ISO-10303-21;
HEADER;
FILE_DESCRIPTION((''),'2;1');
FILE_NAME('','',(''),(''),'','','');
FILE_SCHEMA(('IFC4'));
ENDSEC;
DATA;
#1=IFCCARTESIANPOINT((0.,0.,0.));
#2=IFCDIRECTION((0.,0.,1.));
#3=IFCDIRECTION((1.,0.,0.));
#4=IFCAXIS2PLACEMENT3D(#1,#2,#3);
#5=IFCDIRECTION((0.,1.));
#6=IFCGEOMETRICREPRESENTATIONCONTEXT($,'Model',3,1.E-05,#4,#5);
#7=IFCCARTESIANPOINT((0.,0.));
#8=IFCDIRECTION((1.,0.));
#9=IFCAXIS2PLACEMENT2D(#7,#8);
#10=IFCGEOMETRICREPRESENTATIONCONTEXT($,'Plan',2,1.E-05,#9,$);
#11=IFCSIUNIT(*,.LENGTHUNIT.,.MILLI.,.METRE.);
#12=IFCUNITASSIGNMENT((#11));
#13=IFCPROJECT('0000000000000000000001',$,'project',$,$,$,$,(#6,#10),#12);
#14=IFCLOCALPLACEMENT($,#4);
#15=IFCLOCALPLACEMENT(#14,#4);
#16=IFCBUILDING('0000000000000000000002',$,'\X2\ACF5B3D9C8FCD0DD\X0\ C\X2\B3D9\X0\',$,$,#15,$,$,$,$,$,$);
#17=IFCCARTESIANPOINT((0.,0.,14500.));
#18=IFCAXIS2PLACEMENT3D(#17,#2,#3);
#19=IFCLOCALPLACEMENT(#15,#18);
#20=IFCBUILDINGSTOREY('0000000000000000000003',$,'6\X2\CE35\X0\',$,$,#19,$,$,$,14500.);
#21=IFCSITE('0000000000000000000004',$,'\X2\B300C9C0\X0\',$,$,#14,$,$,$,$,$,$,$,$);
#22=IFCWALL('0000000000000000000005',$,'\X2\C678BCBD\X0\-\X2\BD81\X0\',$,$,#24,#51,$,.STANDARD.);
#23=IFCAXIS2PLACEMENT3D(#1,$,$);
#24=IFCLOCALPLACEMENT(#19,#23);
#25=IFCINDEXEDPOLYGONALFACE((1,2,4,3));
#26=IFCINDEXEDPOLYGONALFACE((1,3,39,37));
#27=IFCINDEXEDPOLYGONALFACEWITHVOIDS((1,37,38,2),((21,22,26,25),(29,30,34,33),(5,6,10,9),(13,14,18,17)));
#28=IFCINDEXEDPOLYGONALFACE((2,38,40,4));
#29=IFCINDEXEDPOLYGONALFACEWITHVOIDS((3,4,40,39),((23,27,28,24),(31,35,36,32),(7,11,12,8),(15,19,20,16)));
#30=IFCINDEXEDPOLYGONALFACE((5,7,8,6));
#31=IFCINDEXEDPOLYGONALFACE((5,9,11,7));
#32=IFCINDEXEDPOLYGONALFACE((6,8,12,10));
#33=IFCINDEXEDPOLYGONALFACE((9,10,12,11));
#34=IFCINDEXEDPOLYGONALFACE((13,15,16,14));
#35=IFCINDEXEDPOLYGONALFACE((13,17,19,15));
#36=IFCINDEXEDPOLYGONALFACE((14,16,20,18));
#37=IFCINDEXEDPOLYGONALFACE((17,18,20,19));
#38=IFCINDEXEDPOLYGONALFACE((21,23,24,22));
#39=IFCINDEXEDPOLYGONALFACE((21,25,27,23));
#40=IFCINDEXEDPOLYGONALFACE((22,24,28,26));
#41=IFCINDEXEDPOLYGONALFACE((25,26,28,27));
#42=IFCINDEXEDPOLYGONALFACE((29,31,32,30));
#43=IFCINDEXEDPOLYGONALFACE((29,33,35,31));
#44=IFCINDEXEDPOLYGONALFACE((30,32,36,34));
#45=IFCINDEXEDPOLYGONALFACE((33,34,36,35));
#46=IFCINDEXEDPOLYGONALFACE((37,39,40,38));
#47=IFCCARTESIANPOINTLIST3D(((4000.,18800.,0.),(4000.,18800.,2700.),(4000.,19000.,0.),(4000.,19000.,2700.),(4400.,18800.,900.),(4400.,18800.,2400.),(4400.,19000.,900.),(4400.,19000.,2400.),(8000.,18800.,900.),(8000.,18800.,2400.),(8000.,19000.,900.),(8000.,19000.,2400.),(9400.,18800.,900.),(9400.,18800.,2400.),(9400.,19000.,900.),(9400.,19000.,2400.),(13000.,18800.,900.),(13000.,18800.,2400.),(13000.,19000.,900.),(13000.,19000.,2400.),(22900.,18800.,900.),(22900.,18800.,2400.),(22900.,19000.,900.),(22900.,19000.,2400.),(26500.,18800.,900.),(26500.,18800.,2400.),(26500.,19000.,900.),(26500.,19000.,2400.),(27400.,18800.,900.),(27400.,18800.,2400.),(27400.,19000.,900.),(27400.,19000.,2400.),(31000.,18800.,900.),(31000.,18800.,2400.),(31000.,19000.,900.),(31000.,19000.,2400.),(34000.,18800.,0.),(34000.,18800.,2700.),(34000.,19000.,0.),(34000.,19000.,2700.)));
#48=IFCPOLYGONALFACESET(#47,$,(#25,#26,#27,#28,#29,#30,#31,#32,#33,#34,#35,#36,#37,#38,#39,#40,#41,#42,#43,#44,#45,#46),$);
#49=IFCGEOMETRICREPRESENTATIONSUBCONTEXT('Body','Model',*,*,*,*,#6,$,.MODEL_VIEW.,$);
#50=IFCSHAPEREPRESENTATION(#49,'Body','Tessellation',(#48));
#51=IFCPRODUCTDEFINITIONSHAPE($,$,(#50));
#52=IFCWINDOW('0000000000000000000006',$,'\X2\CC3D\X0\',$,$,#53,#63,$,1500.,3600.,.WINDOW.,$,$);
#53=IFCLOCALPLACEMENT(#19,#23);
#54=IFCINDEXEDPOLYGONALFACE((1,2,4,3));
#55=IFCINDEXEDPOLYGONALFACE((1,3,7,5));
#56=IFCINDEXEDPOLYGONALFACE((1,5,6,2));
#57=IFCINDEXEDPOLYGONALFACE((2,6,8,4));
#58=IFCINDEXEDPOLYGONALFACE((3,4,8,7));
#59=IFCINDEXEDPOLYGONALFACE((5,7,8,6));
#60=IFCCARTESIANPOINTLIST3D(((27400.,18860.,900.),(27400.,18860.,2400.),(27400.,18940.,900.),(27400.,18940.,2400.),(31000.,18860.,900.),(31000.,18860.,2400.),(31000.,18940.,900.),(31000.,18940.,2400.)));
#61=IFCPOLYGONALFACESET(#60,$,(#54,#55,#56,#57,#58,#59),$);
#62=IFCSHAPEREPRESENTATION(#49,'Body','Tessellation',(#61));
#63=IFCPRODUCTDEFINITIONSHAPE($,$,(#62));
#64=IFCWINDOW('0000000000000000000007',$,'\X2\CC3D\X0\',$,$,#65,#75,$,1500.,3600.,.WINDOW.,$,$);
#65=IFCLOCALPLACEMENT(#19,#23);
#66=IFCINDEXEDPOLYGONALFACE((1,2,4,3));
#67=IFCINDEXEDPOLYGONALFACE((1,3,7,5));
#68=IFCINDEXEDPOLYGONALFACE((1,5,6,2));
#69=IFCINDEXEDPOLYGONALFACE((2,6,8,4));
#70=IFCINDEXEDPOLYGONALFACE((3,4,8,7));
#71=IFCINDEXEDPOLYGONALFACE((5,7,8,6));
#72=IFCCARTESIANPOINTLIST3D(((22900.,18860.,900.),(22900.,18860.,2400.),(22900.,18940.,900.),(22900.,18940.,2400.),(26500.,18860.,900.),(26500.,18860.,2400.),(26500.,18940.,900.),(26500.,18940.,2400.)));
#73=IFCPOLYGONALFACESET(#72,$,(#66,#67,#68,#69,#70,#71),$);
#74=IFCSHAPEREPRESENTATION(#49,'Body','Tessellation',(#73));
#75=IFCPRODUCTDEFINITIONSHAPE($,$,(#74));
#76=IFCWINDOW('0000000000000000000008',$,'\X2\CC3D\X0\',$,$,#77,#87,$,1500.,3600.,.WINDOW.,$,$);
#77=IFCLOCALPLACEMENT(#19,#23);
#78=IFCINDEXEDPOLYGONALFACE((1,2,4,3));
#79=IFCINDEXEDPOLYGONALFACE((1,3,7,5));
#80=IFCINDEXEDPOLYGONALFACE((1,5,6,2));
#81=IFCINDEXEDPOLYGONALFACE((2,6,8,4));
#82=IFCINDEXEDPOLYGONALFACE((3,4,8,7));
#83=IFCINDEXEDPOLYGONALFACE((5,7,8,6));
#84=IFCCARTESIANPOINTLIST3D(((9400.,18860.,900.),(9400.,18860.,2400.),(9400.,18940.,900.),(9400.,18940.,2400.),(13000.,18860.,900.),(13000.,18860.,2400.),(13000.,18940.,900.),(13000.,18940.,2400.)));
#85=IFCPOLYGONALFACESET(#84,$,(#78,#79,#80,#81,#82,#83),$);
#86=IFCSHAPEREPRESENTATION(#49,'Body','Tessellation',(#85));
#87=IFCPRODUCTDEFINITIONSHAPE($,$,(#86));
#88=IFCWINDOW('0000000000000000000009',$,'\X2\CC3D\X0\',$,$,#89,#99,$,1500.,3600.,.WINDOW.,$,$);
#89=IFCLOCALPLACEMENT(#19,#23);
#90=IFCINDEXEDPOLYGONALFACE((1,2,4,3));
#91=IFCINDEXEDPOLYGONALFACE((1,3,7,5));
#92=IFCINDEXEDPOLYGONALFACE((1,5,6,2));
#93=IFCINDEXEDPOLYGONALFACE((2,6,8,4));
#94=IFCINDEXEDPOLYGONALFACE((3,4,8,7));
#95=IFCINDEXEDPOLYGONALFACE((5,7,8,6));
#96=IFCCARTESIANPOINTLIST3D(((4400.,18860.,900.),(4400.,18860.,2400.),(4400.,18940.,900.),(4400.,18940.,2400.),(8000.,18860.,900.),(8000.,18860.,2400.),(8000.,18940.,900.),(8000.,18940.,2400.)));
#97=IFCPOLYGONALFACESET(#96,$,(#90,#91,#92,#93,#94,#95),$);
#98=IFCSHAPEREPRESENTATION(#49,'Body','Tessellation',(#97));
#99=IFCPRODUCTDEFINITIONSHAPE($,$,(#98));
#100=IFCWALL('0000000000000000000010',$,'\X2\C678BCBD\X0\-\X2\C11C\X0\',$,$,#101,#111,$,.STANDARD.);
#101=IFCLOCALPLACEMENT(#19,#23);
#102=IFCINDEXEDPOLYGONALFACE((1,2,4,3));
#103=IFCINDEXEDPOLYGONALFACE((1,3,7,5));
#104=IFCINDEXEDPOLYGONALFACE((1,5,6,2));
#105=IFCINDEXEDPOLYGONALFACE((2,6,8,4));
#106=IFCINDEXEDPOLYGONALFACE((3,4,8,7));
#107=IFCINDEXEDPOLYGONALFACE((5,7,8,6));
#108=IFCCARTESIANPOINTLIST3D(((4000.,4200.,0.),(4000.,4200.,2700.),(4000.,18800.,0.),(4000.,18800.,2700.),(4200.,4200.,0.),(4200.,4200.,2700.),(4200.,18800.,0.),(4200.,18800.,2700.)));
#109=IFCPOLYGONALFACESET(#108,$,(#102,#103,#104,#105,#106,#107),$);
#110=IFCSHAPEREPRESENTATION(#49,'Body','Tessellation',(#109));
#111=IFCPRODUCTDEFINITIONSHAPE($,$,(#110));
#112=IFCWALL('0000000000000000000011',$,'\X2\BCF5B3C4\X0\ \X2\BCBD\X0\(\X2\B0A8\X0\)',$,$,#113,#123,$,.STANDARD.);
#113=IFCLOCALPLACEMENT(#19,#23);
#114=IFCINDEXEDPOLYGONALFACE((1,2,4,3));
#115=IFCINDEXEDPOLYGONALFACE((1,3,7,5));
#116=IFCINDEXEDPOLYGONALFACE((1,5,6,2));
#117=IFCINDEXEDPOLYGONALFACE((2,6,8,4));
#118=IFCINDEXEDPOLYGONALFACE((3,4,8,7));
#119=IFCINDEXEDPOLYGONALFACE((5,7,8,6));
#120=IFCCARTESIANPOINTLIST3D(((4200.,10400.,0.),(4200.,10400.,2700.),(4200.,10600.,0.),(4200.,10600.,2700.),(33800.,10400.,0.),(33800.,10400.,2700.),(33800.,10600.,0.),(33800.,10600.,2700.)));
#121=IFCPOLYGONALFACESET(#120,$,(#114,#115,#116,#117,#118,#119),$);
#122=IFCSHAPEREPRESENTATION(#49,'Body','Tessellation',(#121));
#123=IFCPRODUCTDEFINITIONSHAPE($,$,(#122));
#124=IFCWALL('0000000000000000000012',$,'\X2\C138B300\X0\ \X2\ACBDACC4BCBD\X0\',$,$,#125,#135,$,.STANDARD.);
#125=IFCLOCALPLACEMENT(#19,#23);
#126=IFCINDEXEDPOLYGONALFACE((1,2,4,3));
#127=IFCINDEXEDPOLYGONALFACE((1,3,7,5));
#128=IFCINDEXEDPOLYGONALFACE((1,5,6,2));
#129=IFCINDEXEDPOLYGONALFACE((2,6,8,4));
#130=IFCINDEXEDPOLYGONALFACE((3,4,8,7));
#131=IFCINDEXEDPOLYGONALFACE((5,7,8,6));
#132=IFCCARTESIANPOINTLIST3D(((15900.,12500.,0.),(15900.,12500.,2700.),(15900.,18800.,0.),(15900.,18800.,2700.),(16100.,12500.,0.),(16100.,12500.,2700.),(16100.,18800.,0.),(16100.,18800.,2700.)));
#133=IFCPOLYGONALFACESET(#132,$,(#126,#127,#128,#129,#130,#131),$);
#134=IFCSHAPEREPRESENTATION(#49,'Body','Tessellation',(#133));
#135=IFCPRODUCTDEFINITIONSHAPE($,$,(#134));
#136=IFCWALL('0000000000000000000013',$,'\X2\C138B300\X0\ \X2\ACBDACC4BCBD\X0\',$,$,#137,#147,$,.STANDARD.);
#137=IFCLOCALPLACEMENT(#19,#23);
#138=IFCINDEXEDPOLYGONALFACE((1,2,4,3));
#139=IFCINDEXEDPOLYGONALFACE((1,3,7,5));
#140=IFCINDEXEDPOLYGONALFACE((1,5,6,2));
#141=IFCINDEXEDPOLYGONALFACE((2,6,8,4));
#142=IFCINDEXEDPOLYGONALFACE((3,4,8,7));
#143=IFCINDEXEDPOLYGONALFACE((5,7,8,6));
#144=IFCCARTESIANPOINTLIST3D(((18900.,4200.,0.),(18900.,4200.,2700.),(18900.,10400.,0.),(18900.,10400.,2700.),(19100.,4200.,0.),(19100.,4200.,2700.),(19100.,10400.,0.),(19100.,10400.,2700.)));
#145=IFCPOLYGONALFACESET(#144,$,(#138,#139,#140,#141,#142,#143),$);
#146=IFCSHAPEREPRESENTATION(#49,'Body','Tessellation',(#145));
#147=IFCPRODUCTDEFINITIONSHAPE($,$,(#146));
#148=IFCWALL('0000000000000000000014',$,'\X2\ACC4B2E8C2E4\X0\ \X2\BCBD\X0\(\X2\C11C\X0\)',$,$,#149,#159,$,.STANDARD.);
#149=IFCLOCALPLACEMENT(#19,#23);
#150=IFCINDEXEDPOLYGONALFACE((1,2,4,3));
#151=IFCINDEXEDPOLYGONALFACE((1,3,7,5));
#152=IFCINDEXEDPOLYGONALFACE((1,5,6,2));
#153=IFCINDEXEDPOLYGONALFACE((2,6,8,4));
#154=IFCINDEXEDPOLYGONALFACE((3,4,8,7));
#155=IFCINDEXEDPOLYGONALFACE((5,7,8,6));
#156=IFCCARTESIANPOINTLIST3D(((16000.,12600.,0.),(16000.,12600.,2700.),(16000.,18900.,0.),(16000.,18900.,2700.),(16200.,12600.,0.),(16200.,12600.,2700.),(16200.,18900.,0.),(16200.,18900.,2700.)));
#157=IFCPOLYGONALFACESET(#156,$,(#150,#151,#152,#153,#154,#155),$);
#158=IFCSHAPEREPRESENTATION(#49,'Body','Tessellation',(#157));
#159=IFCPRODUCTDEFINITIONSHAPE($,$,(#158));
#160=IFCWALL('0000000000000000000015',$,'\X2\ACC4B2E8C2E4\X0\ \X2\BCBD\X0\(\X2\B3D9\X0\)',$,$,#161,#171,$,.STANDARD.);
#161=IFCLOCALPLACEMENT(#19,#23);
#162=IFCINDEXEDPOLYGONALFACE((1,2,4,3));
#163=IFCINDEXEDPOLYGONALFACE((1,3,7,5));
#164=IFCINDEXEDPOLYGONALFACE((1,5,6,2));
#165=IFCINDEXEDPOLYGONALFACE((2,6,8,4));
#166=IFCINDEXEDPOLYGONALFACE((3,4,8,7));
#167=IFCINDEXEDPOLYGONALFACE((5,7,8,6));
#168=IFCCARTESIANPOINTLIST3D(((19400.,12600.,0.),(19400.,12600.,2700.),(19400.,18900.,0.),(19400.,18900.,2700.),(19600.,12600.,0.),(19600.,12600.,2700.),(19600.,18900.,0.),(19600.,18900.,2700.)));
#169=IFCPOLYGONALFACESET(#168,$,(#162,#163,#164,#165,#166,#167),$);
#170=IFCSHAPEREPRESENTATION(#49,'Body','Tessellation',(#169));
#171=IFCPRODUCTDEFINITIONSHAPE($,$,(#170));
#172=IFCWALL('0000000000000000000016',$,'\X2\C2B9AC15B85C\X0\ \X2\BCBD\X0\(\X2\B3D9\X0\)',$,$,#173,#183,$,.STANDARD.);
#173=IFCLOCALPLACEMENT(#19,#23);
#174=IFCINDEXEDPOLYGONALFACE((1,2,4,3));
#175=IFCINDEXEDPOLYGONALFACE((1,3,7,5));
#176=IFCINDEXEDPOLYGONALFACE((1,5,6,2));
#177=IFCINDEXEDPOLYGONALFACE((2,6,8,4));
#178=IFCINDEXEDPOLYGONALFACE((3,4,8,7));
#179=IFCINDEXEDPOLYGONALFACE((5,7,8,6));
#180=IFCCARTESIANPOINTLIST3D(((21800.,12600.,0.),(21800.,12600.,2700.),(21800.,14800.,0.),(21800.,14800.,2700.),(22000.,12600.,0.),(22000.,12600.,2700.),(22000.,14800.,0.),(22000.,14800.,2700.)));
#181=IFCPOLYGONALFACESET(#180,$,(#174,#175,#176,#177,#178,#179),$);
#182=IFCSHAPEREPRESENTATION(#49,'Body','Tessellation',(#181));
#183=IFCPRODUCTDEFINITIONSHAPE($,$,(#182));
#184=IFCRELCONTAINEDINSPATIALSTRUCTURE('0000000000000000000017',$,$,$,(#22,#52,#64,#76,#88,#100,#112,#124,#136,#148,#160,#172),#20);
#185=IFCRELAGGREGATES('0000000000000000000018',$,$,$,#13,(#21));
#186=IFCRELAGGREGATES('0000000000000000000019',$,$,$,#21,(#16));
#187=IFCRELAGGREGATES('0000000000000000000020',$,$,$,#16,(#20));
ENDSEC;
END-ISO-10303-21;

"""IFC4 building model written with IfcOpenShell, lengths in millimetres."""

from ifc_helpers import new_model, si_unit, direction, frame, origin_with_axes, origin_2d_with_axis, place, context, subcontext, project, spatial, polyline, outline, extrude, element, fill, save


model = new_model("IFC4")

# Units and contexts
model_context = context("Model", 3, precision=1e-05, world=origin_with_axes(), true_north=direction((0.0, 1.0)))
plan_context = context("Plan", 2, precision=1e-05, world=origin_2d_with_axis())
body_context = subcontext(model_context, "Body", "Model", "MODEL_VIEW")
ifc_project = project(units=[si_unit("LENGTHUNIT", "METRE", prefix="MILLI")], contexts=[model_context, plan_context])

# Site, building, storey
site_placement = place(None, origin_with_axes())
site = spatial("IfcSite", under=ifc_project, at=site_placement, Name="대지")
building_placement = place(site_placement, origin_with_axes())
building = spatial("IfcBuilding", under=site, at=building_placement, Name="공동주택 C동")
storey_placement = place(building_placement, frame((0.0, 0.0, 14500.0), z_axis=(0.0, 0.0, 1.0), x_axis=(1.0, 0.0, 0.0)))
storey = spatial("IfcBuildingStorey", under=building, at=storey_placement, Name="6층", Elevation=14500.0)

# Wall, openings, windows
wall_1_placement = place(storey_placement, origin_with_axes())
wall_1 = element("IfcWall", 1, at=wall_1_placement, inside=storey, Name="외벽-북", PredefinedType="STANDARD", context=body_context, shape_type="SweptSolid", body=[
    extrude(outline(polyline([(34000.0, 18800.0), (4000.0, 18800.0), (4000.0, 19000.0), (34000.0, 19000.0), (34000.0, 18800.0)])), origin_with_axes(), (0.0, 0.0, 1.0), 2700.0),
])
opening_1_placement = place(storey_placement, origin_with_axes())
opening_1 = element("IfcOpeningElement", 2, at=opening_1_placement, cuts=wall_1, PredefinedType="OPENING", context=body_context, shape_type="SweptSolid", body=[
    extrude(outline(polyline([(31000.0, 19050.0), (27400.0, 19050.0), (27400.0, 18750.0), (31000.0, 18750.0), (31000.0, 19050.0)])), frame((0.0, 0.0, 900.0), z_axis=(0.0, 0.0, 1.0), x_axis=(1.0, 0.0, 0.0)), (0.0, 0.0, 1.0), 1500.0),
])
opening_2_placement = place(storey_placement, origin_with_axes())
opening_2 = element("IfcOpeningElement", 3, at=opening_2_placement, cuts=wall_1, PredefinedType="OPENING", context=body_context, shape_type="SweptSolid", body=[
    extrude(outline(polyline([(26500.0, 19050.0), (22900.0, 19050.0), (22900.0, 18750.0), (26500.0, 18750.0), (26500.0, 19050.0)])), frame((0.0, 0.0, 900.0), z_axis=(0.0, 0.0, 1.0), x_axis=(1.0, 0.0, 0.0)), (0.0, 0.0, 1.0), 1500.0),
])
opening_3_placement = place(storey_placement, origin_with_axes())
opening_3 = element("IfcOpeningElement", 4, at=opening_3_placement, cuts=wall_1, PredefinedType="OPENING", context=body_context, shape_type="SweptSolid", body=[
    extrude(outline(polyline([(13000.0, 19050.0), (9400.0, 19050.0), (9400.0, 18750.0), (13000.0, 18750.0), (13000.0, 19050.0)])), frame((0.0, 0.0, 900.0), z_axis=(0.0, 0.0, 1.0), x_axis=(1.0, 0.0, 0.0)), (0.0, 0.0, 1.0), 1500.0),
])
opening_4_placement = place(storey_placement, origin_with_axes())
opening_4 = element("IfcOpeningElement", 5, at=opening_4_placement, cuts=wall_1, PredefinedType="OPENING", context=body_context, shape_type="SweptSolid", body=[
    extrude(outline(polyline([(8000.0, 19050.0), (4400.0, 19050.0), (4400.0, 18750.0), (8000.0, 18750.0), (8000.0, 19050.0)])), frame((0.0, 0.0, 900.0), z_axis=(0.0, 0.0, 1.0), x_axis=(1.0, 0.0, 0.0)), (0.0, 0.0, 1.0), 1500.0),
])
window_1_placement = place(storey_placement, origin_with_axes())
window_1 = element("IfcWindow", 6, at=window_1_placement, inside=storey, Name="창", OverallHeight=1500.0, OverallWidth=3600.0, PredefinedType="WINDOW", context=body_context, shape_type="SweptSolid", body=[
    extrude(outline(polyline([(31000.0, 18940.0), (27400.0, 18940.0), (27400.0, 18860.0), (31000.0, 18860.0), (31000.0, 18940.0)])), frame((0.0, 0.0, 900.0), z_axis=(0.0, 0.0, 1.0), x_axis=(1.0, 0.0, 0.0)), (0.0, 0.0, 1.0), 1500.0),
])
fill(opening_1, window_1)
window_2_placement = place(storey_placement, origin_with_axes())
window_2 = element("IfcWindow", 7, at=window_2_placement, inside=storey, Name="창", OverallHeight=1500.0, OverallWidth=3600.0, PredefinedType="WINDOW", context=body_context, shape_type="SweptSolid", body=[
    extrude(outline(polyline([(26500.0, 18940.0), (22900.0, 18940.0), (22900.0, 18860.0), (26500.0, 18860.0), (26500.0, 18940.0)])), frame((0.0, 0.0, 900.0), z_axis=(0.0, 0.0, 1.0), x_axis=(1.0, 0.0, 0.0)), (0.0, 0.0, 1.0), 1500.0),
])
fill(opening_2, window_2)
window_3_placement = place(storey_placement, origin_with_axes())
window_3 = element("IfcWindow", 8, at=window_3_placement, inside=storey, Name="창", OverallHeight=1500.0, OverallWidth=3600.0, PredefinedType="WINDOW", context=body_context, shape_type="SweptSolid", body=[
    extrude(outline(polyline([(13000.0, 18940.0), (9400.0, 18940.0), (9400.0, 18860.0), (13000.0, 18860.0), (13000.0, 18940.0)])), frame((0.0, 0.0, 900.0), z_axis=(0.0, 0.0, 1.0), x_axis=(1.0, 0.0, 0.0)), (0.0, 0.0, 1.0), 1500.0),
])
fill(opening_3, window_3)
window_4_placement = place(storey_placement, origin_with_axes())
window_4 = element("IfcWindow", 9, at=window_4_placement, inside=storey, Name="창", OverallHeight=1500.0, OverallWidth=3600.0, PredefinedType="WINDOW", context=body_context, shape_type="SweptSolid", body=[
    extrude(outline(polyline([(8000.0, 18940.0), (4400.0, 18940.0), (4400.0, 18860.0), (8000.0, 18860.0), (8000.0, 18940.0)])), frame((0.0, 0.0, 900.0), z_axis=(0.0, 0.0, 1.0), x_axis=(1.0, 0.0, 0.0)), (0.0, 0.0, 1.0), 1500.0),
])
fill(opening_4, window_4)

# Walls
wall_2_placement = place(storey_placement, origin_with_axes())
element("IfcWall", 10, at=wall_2_placement, inside=storey, Name="외벽-서", PredefinedType="STANDARD", context=body_context, shape_type="SweptSolid", body=[
    extrude(outline(polyline([(4200.0, 18800.0), (4200.0, 4200.0), (4000.0, 4200.0), (4000.0, 18800.0), (4200.0, 18800.0)])), origin_with_axes(), (0.0, 0.0, 1.0), 2700.0),
])
wall_3_placement = place(storey_placement, origin_with_axes())
element("IfcWall", 11, at=wall_3_placement, inside=storey, Name="복도 벽(남)", PredefinedType="STANDARD", context=body_context, shape_type="SweptSolid", body=[
    extrude(outline(polyline([(4200.0, 10600.0), (33800.0, 10600.0), (33800.0, 10400.0), (4200.0, 10400.0), (4200.0, 10600.0)])), origin_with_axes(), (0.0, 0.0, 1.0), 2700.0),
])
wall_4_placement = place(storey_placement, origin_with_axes())
element("IfcWall", 12, at=wall_4_placement, inside=storey, Name="세대 경계벽", PredefinedType="STANDARD", context=body_context, shape_type="SweptSolid", body=[
    extrude(outline(polyline([(15900.0, 12500.0), (15900.0, 18800.0), (16100.0, 18800.0), (16100.0, 12500.0), (15900.0, 12500.0)])), origin_with_axes(), (0.0, 0.0, 1.0), 2700.0),
])
wall_5_placement = place(storey_placement, origin_with_axes())
element("IfcWall", 13, at=wall_5_placement, inside=storey, Name="세대 경계벽", PredefinedType="STANDARD", context=body_context, shape_type="SweptSolid", body=[
    extrude(outline(polyline([(18900.0, 4200.0), (18900.0, 10400.0), (19100.0, 10400.0), (19100.0, 4200.0), (18900.0, 4200.0)])), origin_with_axes(), (0.0, 0.0, 1.0), 2700.0),
])
wall_6_placement = place(storey_placement, origin_with_axes())
element("IfcWall", 14, at=wall_6_placement, inside=storey, Name="계단실 벽(서)", PredefinedType="STANDARD", context=body_context, shape_type="SweptSolid", body=[
    extrude(outline(polyline([(16000.0, 12600.0), (16000.0, 18900.0), (16200.0, 18900.0), (16200.0, 12600.0), (16000.0, 12600.0)])), origin_with_axes(), (0.0, 0.0, 1.0), 2700.0),
])
wall_7_placement = place(storey_placement, origin_with_axes())
element("IfcWall", 15, at=wall_7_placement, inside=storey, Name="계단실 벽(동)", PredefinedType="STANDARD", context=body_context, shape_type="SweptSolid", body=[
    extrude(outline(polyline([(19400.0, 12600.0), (19400.0, 18900.0), (19600.0, 18900.0), (19600.0, 12600.0), (19400.0, 12600.0)])), origin_with_axes(), (0.0, 0.0, 1.0), 2700.0),
])
wall_8_placement = place(storey_placement, origin_with_axes())
element("IfcWall", 16, at=wall_8_placement, inside=storey, Name="승강로 벽(동)", PredefinedType="STANDARD", context=body_context, shape_type="SweptSolid", body=[
    extrude(outline(polyline([(21800.0, 12600.0), (21800.0, 14800.0), (22000.0, 14800.0), (22000.0, 12600.0), (21800.0, 12600.0)])), origin_with_axes(), (0.0, 0.0, 1.0), 2700.0),
])

save(model, "model.ifc")
